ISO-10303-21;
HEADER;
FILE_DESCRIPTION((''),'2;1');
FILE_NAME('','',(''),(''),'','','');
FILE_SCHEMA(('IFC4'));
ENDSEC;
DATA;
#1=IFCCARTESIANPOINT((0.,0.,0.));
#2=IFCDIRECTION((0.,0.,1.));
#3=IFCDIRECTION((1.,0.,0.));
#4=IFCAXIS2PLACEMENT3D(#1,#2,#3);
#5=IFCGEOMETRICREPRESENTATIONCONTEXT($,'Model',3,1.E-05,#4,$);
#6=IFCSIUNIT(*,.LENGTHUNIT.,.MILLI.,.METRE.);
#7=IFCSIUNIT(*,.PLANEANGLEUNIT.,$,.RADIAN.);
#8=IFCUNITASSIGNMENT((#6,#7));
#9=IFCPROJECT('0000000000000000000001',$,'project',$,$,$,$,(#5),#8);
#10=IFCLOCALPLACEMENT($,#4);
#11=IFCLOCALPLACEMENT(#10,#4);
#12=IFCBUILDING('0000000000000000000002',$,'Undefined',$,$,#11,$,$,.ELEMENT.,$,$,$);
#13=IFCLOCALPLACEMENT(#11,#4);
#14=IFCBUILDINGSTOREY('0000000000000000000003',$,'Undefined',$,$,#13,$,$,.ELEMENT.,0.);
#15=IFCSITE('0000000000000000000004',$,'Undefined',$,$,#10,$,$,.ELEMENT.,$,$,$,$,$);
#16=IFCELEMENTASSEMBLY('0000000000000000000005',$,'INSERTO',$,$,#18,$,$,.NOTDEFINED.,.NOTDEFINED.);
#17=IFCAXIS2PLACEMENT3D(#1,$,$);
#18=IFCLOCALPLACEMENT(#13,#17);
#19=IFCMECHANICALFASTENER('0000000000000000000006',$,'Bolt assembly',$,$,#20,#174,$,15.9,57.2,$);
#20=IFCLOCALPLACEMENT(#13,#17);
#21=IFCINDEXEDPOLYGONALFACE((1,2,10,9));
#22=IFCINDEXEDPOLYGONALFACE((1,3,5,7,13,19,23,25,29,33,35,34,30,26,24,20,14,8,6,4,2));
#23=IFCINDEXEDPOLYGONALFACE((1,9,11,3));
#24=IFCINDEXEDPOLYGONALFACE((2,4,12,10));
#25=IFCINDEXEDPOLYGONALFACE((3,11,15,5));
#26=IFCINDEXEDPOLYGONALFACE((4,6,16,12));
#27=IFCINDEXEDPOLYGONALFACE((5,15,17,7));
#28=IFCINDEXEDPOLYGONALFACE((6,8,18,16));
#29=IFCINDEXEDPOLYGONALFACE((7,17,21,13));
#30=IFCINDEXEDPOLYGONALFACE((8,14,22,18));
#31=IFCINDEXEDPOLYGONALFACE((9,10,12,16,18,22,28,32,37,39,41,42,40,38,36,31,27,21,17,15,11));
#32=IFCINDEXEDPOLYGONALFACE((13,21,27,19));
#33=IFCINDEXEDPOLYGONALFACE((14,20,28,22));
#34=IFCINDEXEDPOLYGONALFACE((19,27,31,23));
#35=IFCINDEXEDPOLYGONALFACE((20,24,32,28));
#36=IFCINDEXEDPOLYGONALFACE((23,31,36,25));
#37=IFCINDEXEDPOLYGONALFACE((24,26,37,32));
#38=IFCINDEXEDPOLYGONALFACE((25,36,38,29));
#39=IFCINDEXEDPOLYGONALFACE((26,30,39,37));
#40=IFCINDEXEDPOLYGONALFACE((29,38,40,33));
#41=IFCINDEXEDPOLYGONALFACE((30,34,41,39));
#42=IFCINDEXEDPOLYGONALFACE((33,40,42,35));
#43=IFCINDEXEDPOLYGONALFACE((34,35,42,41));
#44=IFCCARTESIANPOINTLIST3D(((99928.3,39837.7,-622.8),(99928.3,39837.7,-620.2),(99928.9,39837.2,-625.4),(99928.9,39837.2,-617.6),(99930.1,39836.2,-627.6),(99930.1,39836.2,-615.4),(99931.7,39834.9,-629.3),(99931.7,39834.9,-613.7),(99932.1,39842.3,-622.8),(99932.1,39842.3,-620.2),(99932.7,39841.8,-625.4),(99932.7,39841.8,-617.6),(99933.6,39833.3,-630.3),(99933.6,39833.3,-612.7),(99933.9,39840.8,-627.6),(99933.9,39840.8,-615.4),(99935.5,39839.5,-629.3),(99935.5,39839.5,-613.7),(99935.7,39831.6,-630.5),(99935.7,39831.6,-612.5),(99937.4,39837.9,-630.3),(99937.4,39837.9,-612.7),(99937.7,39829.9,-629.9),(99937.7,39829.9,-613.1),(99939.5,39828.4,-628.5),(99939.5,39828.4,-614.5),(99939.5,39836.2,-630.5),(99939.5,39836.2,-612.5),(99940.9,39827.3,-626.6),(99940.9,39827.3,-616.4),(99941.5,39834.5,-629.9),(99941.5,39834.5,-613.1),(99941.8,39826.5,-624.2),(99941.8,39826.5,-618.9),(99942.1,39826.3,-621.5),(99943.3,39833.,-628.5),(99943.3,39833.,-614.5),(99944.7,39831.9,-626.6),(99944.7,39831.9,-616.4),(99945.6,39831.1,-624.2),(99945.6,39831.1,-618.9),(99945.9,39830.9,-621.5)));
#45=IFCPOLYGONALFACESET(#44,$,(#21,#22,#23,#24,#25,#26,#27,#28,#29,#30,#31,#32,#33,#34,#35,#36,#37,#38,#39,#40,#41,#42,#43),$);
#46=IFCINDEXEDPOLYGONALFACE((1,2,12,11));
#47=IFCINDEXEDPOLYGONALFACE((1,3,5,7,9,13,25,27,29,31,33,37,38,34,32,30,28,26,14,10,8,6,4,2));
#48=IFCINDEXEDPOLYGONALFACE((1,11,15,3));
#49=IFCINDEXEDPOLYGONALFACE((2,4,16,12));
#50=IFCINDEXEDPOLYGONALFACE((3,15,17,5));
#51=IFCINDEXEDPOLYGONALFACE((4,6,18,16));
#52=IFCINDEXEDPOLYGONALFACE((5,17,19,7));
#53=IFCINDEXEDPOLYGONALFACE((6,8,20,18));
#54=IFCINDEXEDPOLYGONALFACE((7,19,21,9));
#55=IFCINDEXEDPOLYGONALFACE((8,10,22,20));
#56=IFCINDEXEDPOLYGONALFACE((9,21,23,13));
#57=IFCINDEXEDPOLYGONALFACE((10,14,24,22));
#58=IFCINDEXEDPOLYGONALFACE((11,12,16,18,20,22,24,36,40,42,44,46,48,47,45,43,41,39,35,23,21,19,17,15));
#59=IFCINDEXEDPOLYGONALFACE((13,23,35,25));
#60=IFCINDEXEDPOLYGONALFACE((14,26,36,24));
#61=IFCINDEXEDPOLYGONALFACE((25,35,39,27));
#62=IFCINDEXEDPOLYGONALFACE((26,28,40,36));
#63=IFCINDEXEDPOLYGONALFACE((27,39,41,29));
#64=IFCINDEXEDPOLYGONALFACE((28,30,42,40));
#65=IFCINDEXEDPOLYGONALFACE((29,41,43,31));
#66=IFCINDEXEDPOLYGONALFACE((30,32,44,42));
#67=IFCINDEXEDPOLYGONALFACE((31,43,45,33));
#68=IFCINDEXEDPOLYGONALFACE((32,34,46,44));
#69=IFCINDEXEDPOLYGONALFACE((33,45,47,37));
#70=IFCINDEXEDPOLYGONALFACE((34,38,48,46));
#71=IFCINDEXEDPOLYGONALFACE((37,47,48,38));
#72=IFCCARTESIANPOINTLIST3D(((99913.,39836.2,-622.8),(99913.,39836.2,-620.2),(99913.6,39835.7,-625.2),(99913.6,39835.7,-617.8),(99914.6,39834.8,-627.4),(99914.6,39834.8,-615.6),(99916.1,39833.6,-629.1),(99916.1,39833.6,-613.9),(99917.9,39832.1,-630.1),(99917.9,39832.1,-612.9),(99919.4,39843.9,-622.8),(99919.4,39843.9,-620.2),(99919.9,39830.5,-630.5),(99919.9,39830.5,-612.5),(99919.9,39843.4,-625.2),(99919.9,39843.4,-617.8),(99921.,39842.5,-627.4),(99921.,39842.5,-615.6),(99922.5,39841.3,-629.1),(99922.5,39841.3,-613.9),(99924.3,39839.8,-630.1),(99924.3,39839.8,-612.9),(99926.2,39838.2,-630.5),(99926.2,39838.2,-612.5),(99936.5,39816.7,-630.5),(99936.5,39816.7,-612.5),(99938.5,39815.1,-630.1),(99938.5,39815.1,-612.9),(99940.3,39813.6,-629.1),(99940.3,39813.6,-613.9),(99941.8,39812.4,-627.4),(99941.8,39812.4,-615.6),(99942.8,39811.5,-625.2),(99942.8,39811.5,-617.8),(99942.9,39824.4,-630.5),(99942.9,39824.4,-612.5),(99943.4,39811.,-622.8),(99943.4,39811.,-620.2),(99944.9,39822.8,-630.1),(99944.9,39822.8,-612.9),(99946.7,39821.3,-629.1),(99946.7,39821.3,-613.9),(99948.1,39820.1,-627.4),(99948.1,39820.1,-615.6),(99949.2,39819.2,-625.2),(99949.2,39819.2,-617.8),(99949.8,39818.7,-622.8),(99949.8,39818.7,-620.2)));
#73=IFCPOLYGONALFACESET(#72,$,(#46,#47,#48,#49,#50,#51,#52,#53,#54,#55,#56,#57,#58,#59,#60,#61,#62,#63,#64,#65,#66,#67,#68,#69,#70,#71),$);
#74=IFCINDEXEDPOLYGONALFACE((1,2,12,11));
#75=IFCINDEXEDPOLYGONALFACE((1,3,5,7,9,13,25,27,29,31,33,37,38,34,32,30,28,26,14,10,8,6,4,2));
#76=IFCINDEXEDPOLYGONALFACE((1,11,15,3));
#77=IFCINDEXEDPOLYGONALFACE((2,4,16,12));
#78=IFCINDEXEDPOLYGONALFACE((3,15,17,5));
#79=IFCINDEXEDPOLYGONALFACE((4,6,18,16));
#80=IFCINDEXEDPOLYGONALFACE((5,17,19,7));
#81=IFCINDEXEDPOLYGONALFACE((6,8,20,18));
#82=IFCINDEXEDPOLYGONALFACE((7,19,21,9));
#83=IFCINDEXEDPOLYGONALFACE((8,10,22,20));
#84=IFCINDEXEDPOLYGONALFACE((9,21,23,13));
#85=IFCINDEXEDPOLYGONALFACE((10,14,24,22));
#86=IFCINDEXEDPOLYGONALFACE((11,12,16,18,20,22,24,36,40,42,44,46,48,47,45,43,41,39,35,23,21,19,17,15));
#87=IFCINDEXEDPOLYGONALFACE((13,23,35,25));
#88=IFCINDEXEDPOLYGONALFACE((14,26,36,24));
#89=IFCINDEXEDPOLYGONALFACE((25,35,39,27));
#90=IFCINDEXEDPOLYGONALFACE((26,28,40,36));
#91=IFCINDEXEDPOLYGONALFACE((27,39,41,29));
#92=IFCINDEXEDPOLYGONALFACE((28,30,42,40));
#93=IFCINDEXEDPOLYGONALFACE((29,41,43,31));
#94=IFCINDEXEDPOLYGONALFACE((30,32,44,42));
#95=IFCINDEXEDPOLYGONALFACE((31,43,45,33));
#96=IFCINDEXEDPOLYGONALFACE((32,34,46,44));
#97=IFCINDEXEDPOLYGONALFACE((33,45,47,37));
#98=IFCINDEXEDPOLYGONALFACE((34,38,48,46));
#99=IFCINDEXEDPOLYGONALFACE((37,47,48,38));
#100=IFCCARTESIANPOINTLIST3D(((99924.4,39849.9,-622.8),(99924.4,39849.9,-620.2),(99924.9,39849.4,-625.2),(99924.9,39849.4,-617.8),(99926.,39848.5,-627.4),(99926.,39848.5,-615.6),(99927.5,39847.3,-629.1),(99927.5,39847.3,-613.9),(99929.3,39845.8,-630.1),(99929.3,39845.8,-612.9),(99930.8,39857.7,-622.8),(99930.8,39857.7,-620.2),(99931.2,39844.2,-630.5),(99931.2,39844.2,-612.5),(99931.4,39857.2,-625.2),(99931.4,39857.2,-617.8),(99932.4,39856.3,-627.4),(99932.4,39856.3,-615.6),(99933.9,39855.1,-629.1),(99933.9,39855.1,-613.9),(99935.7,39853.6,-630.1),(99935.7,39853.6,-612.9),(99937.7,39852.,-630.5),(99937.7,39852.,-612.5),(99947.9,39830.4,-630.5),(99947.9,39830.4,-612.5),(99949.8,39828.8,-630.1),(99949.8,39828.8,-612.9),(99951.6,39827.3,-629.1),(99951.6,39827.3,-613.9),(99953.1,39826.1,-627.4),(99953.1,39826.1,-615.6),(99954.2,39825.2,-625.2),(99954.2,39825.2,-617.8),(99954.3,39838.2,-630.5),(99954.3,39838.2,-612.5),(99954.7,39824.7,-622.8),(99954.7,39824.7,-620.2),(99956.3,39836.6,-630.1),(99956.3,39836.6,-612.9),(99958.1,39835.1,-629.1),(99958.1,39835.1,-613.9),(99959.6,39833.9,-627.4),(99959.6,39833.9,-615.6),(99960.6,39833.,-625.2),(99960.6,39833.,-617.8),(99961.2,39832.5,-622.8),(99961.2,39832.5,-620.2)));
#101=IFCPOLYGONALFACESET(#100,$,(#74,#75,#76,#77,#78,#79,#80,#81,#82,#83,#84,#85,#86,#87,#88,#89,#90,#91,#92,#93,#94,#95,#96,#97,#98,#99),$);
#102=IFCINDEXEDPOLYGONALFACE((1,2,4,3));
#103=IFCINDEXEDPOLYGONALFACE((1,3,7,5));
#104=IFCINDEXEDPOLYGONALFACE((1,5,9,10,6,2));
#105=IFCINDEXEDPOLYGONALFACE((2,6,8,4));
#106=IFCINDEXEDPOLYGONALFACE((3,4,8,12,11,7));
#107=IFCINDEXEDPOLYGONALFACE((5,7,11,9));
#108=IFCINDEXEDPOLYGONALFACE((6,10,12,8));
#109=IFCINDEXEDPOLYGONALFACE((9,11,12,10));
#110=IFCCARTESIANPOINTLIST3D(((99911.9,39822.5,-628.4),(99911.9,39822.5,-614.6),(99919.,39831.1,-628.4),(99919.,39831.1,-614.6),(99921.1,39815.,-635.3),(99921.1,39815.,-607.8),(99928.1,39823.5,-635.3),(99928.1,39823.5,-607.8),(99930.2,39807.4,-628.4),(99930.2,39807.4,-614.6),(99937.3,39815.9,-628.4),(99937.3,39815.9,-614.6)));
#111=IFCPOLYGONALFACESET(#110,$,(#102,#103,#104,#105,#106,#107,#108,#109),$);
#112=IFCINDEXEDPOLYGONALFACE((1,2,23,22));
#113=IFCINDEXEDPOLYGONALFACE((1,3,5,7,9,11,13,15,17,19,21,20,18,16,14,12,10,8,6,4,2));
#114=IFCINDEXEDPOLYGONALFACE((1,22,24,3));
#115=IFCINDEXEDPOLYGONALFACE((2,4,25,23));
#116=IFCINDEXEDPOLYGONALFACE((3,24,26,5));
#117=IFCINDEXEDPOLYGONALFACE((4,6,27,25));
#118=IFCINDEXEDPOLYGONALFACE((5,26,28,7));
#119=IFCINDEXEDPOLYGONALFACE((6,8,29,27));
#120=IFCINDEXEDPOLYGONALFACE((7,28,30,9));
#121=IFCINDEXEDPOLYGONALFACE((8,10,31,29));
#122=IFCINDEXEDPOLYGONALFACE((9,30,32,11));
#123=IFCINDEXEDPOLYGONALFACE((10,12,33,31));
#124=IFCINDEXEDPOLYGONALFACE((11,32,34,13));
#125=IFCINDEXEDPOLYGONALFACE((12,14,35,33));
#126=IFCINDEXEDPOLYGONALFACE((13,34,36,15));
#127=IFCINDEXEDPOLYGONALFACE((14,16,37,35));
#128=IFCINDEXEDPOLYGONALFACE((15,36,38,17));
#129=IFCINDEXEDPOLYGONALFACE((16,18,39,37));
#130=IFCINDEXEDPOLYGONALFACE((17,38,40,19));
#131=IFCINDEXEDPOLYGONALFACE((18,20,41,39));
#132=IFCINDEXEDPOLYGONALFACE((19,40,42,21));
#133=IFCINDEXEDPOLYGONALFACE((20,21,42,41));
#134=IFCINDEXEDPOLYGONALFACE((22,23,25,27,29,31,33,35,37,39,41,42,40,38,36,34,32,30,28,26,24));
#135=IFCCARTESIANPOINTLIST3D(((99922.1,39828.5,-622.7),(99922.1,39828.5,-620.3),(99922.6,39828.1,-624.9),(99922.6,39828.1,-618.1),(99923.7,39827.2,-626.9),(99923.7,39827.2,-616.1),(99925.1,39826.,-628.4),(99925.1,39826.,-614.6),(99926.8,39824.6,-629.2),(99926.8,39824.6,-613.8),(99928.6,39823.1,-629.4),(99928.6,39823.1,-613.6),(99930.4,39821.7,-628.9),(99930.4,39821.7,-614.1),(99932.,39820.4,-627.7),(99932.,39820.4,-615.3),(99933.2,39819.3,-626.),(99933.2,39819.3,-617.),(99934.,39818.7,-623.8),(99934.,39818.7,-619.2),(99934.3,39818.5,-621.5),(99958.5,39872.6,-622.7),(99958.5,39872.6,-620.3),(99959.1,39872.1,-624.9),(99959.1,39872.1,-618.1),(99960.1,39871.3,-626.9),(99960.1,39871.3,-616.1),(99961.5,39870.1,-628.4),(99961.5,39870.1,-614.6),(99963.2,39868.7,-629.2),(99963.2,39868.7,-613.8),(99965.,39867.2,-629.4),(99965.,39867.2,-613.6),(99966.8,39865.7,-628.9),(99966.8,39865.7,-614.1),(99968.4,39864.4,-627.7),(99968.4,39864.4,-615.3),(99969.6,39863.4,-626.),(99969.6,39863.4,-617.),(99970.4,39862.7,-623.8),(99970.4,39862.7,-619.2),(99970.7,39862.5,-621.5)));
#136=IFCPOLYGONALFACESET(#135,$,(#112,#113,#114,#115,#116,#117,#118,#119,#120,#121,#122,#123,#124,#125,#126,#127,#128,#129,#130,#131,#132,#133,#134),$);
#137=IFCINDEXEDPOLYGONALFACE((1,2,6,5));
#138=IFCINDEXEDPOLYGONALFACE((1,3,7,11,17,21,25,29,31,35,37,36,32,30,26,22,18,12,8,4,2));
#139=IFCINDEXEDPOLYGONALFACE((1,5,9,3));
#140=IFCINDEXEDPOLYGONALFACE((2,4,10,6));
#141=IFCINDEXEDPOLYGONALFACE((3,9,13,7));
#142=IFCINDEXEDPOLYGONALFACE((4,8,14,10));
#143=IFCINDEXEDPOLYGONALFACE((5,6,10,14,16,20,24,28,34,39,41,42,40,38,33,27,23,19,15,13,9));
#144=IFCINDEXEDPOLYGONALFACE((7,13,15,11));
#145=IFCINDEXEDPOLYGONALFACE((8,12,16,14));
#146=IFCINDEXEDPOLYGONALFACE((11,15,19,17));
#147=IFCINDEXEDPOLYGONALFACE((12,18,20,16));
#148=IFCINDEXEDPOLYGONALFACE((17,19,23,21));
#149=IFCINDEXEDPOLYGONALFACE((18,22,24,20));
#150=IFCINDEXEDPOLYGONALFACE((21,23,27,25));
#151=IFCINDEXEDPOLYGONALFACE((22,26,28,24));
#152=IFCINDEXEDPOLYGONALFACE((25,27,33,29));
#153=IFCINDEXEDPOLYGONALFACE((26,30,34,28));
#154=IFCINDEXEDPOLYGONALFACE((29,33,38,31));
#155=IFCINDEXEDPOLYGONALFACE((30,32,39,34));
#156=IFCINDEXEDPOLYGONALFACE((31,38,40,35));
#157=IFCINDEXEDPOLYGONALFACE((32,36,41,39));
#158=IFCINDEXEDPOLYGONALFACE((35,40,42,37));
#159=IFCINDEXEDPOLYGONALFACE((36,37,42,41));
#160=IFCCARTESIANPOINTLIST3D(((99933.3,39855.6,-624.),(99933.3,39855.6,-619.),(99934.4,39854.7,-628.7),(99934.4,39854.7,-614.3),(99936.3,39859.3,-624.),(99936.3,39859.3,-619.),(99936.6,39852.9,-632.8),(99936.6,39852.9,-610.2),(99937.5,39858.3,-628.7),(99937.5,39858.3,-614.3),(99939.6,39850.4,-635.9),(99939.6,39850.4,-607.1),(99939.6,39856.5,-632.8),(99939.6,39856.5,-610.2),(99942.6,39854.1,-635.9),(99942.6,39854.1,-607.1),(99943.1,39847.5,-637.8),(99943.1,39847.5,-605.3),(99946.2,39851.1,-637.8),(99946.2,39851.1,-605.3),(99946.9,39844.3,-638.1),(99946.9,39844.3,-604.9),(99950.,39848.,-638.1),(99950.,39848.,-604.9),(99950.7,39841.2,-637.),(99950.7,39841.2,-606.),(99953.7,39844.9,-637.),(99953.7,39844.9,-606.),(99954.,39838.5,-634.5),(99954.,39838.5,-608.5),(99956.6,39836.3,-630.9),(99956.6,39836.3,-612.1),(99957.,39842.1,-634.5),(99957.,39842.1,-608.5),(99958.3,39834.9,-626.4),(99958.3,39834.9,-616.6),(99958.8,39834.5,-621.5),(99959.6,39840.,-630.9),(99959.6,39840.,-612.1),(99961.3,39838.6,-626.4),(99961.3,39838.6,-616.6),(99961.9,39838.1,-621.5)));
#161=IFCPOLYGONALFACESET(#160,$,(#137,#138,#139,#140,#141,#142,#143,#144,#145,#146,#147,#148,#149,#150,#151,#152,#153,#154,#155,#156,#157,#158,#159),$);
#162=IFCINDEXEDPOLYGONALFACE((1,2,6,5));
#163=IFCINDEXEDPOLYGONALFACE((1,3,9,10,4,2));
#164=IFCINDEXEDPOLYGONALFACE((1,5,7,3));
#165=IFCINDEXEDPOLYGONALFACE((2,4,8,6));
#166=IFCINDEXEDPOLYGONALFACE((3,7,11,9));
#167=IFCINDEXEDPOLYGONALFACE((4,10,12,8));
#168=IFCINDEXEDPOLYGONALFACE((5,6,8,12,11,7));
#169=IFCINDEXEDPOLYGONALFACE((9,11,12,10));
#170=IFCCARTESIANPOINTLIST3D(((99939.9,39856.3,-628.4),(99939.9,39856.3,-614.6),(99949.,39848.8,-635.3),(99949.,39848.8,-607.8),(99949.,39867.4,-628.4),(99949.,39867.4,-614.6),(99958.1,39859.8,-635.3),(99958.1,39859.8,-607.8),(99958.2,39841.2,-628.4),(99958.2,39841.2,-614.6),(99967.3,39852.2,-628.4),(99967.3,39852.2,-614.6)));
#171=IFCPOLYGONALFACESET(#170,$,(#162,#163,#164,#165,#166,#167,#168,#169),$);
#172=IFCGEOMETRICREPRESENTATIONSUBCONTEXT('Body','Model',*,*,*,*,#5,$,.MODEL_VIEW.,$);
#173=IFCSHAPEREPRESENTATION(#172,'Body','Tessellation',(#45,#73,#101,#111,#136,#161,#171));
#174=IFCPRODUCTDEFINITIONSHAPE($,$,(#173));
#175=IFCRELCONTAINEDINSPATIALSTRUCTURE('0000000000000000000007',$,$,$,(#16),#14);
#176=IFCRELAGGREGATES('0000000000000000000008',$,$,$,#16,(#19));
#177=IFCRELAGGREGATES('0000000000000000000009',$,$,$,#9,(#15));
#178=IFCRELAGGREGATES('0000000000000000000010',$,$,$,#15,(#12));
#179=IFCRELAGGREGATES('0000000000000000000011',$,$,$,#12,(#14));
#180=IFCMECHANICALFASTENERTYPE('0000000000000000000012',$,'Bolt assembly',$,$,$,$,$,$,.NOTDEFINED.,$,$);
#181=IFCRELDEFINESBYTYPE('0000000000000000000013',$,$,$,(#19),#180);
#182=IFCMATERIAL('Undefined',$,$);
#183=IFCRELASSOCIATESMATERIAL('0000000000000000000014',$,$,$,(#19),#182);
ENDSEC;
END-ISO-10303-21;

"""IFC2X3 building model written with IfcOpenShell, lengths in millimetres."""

from ifc_helpers import new_model, entity, si_unit, frame, origin_with_axes, origin_2d_with_axis, place, context, subcontext, project, spatial, polyline, circle, outline, extrude, source, transform, mapped, material, type_object, element, aggregate, save


model = new_model("IFC2X3")

# Units and contexts
model_context = context("Model", 3, precision=1e-05, world=origin_with_axes())
body_context = subcontext(model_context, "Body", "Model", "MODEL_VIEW")
ifc_project = project(units=[si_unit("LENGTHUNIT", "METRE", prefix="MILLI"), si_unit("PLANEANGLEUNIT", "RADIAN")], contexts=[model_context])

# Site, building, storey
site_placement = place(None, origin_with_axes())
site = spatial("IfcSite", under=ifc_project, at=site_placement, Name="Undefined", CompositionType="ELEMENT")
building_placement = place(site_placement, origin_with_axes())
building = spatial("IfcBuilding", under=site, at=building_placement, Name="Undefined", CompositionType="ELEMENT")
storey_placement = place(building_placement, origin_with_axes())
storey = spatial("IfcBuildingStorey", under=building, at=storey_placement, Name="Undefined", CompositionType="ELEMENT", Elevation=0.0)

# Element assembly
assembly_1_placement = place(storey_placement, origin_with_axes())
assembly_1 = element("IfcElementAssembly", 1, at=assembly_1_placement, inside=storey, Name="INSERTO", AssemblyPlace="NOTDEFINED", PredefinedType="NOTDEFINED")

# Mechanical fastener
ifc_material_1 = material(Name="Undefined")
mechanical_fastener_type = type_object("IfcMechanicalFastenerType", Name="Bolt assembly")
shared_circle_1 = entity("IfcCircle", entity("IfcAxis2Placement2D", entity("IfcCartesianPoint", [10.8, 0.0]), entity("IfcDirection", [0.0, 1.0])), 9.0)
shared_circle_2 = entity("IfcCircle", entity("IfcAxis2Placement2D", entity("IfcCartesianPoint", [-10.8, 0.0]), entity("IfcDirection", [0.0, -1.0])), 9.0)
shared_composite_curve = entity("IfcCompositeCurve", [entity("IfcCompositeCurveSegment", "CONTINUOUS", True, entity("IfcPolyline", [entity("IfcCartesianPoint", [-10.8, 9.0]), entity("IfcCartesianPoint", [10.8, 9.0])])), entity("IfcCompositeCurveSegment", "CONTINUOUS", True, entity("IfcTrimmedCurve", shared_circle_1, [entity("IfcParameterValue", 0.0)], [entity("IfcParameterValue", 3.141593)], False, "PARAMETER")), entity("IfcCompositeCurveSegment", "CONTINUOUS", True, entity("IfcPolyline", [entity("IfcCartesianPoint", [10.8, -9.0]), entity("IfcCartesianPoint", [-10.8, -9.0])])), entity("IfcCompositeCurveSegment", "DISCONTINUOUS", True, entity("IfcTrimmedCurve", shared_circle_2, [entity("IfcParameterValue", 0.0)], [entity("IfcParameterValue", 3.141593)], False, "PARAMETER"))], False)
shared_shape_1 = source(origin_with_axes(), body_context, "Body", "SweptSolid", [
    extrude(circle(Radius=9.0, at=origin_2d_with_axis()), frame((0.0, 6.0, 0.0), z_axis=(0.0, 1.0, 0.0), x_axis=(1.0, 0.0, 0.0)), (0.0, 0.0, 1.0), 6.0),
    entity("IfcExtrudedAreaSolid", entity("IfcArbitraryClosedProfileDef", "AREA", None, shared_composite_curve), entity("IfcAxis2Placement3D", entity("IfcCartesianPoint", [0.0, -4.9, 0.0]), entity("IfcDirection", [0.0, 1.0, 0.0]), entity("IfcDirection", [1.0, 0.0, 0.0])), entity("IfcDirection", [0.0, 0.0, 1.0]), 10.0),
    entity("IfcExtrudedAreaSolid", entity("IfcArbitraryClosedProfileDef", "AREA", None, shared_composite_curve), entity("IfcAxis2Placement3D", entity("IfcCartesianPoint", [0.0, 12.9, 0.0]), entity("IfcDirection", [0.0, 1.0, 0.0]), entity("IfcDirection", [1.0, 0.0, 0.0])), entity("IfcDirection", [0.0, 0.0, 1.0]), 10.1),
    extrude(outline(polyline([(11.9, -6.9), (11.9, 6.9), (0.0, 13.7), (-11.9, 6.9), (-11.9, -6.9), (0.0, -13.7), (11.9, -6.9)])), frame((0.0, -16.1, 0.0), z_axis=(0.0, 1.0, 0.0), x_axis=(1.0, 0.0, 0.0)), (0.0, 0.0, 1.0), 11.1),
    extrude(circle(Radius=7.9, at=origin_2d_with_axis()), frame((0.0, -5.0, 0.0), z_axis=(0.0, 1.0, 0.0), x_axis=(1.0, 0.0, 0.0)), (0.0, 0.0, 1.0), 57.1),
    extrude(circle(Radius=16.7, at=origin_2d_with_axis()), frame((0.0, 23.0, 0.0), z_axis=(0.0, 1.0, 0.0), x_axis=(1.0, 0.0, 0.0)), (0.0, 0.0, 1.0), 4.8),
    extrude(outline(polyline([(11.9, -6.9), (11.9, 6.9), (0.0, 13.7), (-11.9, 6.9), (-11.9, -6.9), (0.0, -13.7), (11.9, -6.9)])), frame((0.0, 27.8, 0.0), z_axis=(0.0, 1.0, 0.0), x_axis=(1.0, 0.0, 0.0)), (0.0, 0.0, 1.0), 14.3),
])
mechanical_fastener_1_placement = place(assembly_1_placement, frame((99931.3, 39827.4, -621.5), z_axis=(0.0, 0.0, 1.0), x_axis=(0.7704, -0.63756, 0.0)))
mechanical_fastener_1 = element("IfcMechanicalFastener", 2, at=mechanical_fastener_1_placement, type_object=mechanical_fastener_type, material=ifc_material_1, Name="Bolt assembly", NominalDiameter=15.9, NominalLength=57.2, context=body_context, shape_type="MappedRepresentation", body=[
    mapped(shared_shape_1, transform((0.0, 0.0, 0.0))),
])
aggregate(assembly_1, [mechanical_fastener_1])

save(model, "model.ifc")
